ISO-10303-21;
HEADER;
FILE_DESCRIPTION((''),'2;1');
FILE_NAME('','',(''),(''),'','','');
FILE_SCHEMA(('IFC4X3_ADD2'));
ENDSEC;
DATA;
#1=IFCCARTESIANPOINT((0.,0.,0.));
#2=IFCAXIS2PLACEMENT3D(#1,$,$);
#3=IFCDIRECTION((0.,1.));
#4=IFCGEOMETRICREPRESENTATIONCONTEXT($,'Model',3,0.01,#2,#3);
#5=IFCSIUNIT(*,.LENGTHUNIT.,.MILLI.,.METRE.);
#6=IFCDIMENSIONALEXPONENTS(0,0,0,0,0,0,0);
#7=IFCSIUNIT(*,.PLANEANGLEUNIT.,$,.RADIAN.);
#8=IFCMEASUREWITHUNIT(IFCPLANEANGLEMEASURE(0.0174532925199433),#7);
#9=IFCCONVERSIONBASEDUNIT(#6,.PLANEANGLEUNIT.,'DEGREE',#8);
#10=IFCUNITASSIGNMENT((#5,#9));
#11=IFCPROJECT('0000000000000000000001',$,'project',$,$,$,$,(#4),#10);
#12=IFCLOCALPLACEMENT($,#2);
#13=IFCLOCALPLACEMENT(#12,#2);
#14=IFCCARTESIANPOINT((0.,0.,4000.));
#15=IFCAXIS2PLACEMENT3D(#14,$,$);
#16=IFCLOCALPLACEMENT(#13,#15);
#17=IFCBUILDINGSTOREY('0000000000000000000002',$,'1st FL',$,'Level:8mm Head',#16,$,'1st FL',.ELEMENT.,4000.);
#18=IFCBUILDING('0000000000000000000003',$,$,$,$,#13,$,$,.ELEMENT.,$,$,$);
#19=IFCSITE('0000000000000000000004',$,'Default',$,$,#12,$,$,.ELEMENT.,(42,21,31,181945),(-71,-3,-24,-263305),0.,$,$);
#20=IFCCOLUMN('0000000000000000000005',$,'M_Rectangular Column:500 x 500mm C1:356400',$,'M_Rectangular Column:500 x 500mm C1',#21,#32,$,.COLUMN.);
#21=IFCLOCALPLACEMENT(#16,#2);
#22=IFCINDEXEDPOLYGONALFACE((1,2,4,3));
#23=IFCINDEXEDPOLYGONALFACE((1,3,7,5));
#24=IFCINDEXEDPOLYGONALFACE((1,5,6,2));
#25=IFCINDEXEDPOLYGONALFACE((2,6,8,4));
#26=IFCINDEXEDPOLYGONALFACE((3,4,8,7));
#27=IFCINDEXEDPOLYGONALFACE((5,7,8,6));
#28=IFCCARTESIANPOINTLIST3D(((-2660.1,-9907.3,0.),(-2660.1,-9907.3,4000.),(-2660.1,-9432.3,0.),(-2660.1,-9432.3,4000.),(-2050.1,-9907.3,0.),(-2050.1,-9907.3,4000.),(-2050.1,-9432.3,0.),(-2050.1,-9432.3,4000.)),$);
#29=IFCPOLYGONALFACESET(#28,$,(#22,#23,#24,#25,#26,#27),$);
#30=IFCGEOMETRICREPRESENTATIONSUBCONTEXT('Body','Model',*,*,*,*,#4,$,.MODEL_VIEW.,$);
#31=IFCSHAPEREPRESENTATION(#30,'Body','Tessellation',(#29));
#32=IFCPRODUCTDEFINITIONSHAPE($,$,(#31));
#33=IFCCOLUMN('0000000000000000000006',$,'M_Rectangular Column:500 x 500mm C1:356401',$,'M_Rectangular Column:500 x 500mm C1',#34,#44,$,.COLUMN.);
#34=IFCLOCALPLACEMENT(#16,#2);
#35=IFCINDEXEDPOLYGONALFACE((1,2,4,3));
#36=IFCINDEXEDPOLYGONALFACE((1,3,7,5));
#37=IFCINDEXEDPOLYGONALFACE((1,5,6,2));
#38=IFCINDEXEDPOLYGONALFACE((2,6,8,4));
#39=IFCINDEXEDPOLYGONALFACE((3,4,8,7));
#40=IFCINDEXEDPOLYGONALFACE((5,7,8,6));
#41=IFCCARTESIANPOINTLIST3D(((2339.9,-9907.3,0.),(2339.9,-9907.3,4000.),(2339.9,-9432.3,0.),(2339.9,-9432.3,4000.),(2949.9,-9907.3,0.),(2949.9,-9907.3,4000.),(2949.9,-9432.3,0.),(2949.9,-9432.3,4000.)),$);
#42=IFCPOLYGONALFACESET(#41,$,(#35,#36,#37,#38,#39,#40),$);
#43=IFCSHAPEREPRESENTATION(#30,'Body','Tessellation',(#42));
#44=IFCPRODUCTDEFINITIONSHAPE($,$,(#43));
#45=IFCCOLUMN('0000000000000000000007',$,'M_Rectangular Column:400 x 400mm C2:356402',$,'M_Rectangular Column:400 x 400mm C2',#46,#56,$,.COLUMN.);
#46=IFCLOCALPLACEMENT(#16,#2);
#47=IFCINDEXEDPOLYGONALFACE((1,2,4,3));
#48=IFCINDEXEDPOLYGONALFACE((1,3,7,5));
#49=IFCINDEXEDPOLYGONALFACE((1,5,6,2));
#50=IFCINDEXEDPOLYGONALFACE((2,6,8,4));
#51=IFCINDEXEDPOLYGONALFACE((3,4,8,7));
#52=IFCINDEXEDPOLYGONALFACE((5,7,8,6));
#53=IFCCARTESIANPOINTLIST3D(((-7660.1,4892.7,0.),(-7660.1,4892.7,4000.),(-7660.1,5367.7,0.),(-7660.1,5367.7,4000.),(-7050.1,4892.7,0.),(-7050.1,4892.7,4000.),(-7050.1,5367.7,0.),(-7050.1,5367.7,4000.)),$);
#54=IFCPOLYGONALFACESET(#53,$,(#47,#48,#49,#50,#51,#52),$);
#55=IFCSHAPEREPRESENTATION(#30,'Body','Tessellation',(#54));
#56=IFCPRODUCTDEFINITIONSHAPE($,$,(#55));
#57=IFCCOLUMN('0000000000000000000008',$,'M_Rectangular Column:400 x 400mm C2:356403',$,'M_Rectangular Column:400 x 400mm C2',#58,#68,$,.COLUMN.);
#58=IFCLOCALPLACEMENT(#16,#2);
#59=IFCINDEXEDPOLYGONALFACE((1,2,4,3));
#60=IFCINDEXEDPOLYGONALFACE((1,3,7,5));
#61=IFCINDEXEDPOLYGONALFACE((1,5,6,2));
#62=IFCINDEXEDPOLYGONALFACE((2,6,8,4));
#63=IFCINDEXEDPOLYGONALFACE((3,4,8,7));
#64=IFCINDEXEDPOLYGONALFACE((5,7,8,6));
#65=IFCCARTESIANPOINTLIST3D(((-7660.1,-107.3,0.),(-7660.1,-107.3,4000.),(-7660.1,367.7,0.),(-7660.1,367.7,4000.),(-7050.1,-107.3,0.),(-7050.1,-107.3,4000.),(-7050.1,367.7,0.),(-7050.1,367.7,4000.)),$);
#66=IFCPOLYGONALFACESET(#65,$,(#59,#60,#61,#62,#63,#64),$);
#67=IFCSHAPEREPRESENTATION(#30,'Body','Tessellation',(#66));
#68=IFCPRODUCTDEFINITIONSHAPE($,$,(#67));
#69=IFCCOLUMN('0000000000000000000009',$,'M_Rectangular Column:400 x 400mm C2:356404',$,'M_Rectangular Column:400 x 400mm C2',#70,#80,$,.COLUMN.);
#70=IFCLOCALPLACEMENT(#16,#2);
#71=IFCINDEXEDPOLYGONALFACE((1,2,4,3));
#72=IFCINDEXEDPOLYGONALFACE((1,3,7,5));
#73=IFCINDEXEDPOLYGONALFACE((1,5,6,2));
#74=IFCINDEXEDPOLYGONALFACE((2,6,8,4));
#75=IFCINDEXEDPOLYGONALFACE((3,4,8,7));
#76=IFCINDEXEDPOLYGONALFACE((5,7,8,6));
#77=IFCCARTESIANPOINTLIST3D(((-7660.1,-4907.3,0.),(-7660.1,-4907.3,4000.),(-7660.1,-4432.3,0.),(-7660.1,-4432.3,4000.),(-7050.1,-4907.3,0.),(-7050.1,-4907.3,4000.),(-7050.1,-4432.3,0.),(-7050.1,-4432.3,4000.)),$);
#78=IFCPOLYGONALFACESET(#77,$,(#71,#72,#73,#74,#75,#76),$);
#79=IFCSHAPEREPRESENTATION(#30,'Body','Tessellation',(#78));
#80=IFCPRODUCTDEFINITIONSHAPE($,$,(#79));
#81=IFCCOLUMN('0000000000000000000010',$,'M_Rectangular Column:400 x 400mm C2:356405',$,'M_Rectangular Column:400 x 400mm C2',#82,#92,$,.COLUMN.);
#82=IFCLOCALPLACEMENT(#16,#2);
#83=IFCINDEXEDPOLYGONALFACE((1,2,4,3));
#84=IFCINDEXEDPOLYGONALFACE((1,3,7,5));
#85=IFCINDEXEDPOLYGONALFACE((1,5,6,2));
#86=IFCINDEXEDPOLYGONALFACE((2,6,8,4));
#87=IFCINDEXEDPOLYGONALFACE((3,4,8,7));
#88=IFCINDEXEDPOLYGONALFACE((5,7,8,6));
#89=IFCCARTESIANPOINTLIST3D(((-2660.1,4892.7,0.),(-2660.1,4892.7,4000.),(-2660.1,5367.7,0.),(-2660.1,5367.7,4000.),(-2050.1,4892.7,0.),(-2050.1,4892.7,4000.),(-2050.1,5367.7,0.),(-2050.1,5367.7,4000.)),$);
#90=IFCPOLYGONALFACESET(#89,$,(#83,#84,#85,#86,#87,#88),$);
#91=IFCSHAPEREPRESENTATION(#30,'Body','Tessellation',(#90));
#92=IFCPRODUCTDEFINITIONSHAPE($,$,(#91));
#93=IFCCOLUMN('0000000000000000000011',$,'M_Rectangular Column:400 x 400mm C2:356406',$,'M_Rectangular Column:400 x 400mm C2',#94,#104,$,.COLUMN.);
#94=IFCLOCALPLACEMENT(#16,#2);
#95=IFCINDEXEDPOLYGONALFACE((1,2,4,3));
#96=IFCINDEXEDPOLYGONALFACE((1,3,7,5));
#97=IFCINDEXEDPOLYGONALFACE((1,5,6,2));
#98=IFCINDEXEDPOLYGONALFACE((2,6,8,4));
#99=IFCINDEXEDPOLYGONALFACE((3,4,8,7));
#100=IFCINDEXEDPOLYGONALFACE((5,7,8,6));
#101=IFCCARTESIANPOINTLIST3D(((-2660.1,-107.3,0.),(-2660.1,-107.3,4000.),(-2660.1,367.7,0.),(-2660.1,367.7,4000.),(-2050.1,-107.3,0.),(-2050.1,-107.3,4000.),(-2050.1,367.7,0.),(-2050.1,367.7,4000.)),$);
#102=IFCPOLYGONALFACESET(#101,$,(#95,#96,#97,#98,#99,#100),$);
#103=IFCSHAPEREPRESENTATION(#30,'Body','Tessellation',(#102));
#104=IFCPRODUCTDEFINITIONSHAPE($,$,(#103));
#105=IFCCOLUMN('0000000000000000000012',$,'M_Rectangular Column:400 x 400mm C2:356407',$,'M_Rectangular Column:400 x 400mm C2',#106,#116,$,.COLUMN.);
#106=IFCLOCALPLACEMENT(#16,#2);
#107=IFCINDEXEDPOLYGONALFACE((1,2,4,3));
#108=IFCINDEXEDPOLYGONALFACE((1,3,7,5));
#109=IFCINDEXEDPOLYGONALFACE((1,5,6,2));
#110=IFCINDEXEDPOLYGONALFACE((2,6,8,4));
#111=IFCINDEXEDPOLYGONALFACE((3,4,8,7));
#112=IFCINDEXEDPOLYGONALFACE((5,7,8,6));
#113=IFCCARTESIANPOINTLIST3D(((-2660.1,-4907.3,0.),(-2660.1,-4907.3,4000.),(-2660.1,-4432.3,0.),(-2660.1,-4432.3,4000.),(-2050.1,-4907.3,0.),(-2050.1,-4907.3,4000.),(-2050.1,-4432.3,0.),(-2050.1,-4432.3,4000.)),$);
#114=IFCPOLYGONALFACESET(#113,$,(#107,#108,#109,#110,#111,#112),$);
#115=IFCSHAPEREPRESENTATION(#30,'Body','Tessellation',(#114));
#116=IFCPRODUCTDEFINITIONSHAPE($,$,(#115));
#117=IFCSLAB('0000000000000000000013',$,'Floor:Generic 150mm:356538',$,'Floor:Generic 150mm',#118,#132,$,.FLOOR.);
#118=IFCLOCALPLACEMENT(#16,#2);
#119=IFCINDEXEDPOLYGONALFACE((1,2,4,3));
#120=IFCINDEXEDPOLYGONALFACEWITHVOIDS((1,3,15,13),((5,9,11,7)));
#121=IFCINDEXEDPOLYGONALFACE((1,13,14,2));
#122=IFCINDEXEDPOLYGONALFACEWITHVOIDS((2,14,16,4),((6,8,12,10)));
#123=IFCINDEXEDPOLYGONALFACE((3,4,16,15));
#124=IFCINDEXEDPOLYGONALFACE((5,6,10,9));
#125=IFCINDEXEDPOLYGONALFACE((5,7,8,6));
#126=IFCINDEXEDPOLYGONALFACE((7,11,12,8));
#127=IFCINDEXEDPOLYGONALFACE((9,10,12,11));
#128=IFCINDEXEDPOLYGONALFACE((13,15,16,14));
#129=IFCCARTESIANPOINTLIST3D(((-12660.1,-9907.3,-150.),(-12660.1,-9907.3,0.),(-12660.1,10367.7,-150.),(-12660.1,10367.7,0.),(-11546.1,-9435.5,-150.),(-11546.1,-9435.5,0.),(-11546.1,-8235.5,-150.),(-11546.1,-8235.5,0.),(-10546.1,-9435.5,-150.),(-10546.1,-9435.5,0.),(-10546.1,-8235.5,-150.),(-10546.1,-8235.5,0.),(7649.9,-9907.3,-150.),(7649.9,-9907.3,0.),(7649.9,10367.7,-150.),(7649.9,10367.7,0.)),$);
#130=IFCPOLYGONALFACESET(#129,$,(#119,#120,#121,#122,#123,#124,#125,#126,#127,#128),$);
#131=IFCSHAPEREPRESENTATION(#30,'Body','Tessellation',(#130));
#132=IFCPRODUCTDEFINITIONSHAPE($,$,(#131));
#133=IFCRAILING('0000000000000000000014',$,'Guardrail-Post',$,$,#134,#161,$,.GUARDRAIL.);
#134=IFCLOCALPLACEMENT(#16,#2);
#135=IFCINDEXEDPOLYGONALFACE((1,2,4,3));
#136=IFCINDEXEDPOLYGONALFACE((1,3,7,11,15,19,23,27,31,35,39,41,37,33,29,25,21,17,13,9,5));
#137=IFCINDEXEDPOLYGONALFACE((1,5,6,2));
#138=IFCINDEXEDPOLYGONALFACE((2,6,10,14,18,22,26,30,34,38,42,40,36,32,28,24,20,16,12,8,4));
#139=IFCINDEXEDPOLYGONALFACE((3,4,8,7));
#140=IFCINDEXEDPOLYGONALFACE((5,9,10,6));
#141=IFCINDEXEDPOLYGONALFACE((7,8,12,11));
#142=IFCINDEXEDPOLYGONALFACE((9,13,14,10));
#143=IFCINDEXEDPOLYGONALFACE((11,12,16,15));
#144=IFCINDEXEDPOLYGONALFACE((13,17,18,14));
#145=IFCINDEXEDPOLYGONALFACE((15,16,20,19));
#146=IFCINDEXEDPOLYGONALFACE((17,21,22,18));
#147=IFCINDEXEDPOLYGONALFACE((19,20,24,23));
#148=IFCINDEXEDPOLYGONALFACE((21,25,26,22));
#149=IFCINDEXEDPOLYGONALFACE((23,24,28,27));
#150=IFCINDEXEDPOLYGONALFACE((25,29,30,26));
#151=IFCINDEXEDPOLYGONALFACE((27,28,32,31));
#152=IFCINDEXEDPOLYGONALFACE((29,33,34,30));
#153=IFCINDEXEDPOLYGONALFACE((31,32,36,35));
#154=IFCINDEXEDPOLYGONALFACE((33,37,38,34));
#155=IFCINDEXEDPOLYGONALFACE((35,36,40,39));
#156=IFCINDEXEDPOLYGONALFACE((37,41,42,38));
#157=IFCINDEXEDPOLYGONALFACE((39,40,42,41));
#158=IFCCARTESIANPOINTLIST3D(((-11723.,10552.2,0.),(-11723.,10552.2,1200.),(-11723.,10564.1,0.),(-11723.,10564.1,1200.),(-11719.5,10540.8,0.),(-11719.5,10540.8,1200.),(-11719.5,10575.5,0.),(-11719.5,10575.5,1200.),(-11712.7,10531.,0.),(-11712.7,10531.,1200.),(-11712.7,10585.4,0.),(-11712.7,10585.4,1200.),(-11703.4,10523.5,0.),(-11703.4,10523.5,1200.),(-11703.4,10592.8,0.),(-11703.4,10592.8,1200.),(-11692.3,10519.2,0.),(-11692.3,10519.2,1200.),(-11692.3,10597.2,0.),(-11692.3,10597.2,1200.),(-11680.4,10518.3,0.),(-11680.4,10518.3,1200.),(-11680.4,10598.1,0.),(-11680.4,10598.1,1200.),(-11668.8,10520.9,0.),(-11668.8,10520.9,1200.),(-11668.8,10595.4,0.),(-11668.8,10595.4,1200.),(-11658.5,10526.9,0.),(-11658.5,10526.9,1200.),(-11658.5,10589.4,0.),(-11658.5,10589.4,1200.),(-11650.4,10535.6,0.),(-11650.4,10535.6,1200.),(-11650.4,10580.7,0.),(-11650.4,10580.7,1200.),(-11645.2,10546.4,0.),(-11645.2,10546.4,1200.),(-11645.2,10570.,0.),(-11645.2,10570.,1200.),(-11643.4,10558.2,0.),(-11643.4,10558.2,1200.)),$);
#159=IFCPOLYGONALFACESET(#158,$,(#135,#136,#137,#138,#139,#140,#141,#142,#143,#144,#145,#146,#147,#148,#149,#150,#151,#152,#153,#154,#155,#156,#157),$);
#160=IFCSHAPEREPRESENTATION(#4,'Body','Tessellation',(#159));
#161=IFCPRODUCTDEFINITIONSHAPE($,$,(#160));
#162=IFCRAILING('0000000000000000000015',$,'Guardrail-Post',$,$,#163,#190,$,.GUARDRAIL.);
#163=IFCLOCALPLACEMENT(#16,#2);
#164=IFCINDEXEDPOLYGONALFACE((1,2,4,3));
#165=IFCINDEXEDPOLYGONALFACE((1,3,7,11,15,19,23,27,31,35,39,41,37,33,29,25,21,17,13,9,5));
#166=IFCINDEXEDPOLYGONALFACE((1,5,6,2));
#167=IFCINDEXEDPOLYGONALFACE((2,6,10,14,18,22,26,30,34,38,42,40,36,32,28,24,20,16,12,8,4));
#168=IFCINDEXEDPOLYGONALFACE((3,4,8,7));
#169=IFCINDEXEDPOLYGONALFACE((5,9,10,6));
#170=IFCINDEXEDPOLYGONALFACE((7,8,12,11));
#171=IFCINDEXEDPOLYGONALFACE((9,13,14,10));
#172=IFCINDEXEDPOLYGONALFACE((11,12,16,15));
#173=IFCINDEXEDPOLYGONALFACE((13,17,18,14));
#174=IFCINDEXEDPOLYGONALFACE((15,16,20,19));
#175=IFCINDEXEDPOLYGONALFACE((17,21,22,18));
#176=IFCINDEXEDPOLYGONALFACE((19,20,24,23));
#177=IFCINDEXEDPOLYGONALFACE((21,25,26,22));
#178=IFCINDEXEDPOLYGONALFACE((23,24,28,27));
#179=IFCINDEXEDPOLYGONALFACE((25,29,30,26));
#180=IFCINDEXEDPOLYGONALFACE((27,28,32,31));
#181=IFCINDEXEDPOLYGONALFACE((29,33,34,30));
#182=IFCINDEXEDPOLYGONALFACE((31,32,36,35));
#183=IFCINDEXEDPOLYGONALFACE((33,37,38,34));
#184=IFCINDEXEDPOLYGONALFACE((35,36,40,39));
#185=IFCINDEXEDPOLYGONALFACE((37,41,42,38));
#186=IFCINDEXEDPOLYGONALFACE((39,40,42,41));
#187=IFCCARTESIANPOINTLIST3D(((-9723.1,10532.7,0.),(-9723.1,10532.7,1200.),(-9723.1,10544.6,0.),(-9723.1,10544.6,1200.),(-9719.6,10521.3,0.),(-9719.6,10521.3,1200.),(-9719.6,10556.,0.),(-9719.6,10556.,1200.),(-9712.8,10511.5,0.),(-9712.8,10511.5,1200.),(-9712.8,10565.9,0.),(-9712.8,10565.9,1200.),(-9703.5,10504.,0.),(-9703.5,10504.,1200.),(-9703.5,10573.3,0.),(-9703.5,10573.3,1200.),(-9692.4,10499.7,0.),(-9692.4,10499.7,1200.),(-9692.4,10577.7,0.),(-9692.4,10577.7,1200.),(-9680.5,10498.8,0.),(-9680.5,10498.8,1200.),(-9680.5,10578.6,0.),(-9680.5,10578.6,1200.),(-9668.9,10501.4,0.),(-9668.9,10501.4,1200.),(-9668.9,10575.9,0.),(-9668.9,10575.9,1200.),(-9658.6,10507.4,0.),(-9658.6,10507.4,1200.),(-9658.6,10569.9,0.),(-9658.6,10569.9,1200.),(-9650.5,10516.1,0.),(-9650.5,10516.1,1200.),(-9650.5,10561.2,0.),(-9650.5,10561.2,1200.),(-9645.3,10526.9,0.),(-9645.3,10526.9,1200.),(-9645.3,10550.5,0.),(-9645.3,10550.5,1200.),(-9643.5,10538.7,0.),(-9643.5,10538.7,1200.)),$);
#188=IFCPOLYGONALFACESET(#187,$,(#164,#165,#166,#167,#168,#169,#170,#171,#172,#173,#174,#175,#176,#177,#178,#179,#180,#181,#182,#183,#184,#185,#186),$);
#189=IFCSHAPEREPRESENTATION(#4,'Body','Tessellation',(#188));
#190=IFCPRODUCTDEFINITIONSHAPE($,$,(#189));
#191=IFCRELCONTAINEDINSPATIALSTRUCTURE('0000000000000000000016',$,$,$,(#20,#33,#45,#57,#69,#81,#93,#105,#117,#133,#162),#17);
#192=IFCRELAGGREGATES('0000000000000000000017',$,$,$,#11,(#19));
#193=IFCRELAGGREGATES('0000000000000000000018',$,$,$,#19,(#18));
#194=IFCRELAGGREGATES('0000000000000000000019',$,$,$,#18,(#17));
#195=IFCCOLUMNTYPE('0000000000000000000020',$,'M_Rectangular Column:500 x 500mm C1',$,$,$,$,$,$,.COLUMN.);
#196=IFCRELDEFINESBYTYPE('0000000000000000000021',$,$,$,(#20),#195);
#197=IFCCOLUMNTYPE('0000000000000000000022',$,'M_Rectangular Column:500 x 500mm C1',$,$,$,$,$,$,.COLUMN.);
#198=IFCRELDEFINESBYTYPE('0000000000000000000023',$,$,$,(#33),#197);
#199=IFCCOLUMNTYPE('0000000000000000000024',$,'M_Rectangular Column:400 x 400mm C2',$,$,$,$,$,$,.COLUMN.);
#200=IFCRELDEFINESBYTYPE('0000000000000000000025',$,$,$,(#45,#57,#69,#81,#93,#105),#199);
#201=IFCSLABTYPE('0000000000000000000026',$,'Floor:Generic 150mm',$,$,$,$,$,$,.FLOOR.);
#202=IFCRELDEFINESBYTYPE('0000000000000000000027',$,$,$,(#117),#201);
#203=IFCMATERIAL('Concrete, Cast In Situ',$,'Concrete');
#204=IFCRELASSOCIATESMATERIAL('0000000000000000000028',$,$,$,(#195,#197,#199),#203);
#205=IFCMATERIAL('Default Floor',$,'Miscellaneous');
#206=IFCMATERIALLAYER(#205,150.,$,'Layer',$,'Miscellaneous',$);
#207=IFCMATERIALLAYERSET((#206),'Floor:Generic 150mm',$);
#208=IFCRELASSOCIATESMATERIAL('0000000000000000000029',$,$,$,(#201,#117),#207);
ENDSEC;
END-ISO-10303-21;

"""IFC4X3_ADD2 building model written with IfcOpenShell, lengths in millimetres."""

from ifc_helpers import new_model, entity, si_unit, converted_unit, direction, frame, frame_2d, origin, origin_with_axes, origin_2d, origin_2d_with_axis, place, context, subcontext, project, spatial, rectangle, circle, extrude, boolean, source, transform, mapped, material, layer, layer_set, layer_usage, material_profile, profile_set, type_object, type_shapes, element, save


model = new_model("IFC4X3_ADD2")

# Units and contexts
model_context = context("Model", 3, precision=0.01, world=origin(), true_north=direction((0.0, 1.0)))
body_context = subcontext(model_context, "Body", "Model", "MODEL_VIEW")
ifc_project = project(units=[si_unit("LENGTHUNIT", "METRE", prefix="MILLI"), converted_unit("PLANEANGLEUNIT", "DEGREE", entity("IfcPlaneAngleMeasure", 0.0174532925199433), si_unit("PLANEANGLEUNIT", "RADIAN"), dimensions=[0, 0, 0, 0, 0, 0, 0])], contexts=[model_context])

# Site, building, storey
site_placement = place(None, origin())
site = spatial("IfcSite", under=ifc_project, at=site_placement, Name="Default", CompositionType="ELEMENT", RefLatitude=(42, 21, 31, 181945), RefLongitude=(-71, -3, -24, -263305), RefElevation=0.0)
building_placement = place(site_placement, origin())
building = spatial("IfcBuilding", under=site, at=building_placement, CompositionType="ELEMENT")
storey_placement = place(building_placement, frame((0.0, 0.0, 4000.0)))
storey = spatial("IfcBuildingStorey", under=building, at=storey_placement, Name="1st FL", ObjectType="Level:8mm Head", LongName="1st FL", CompositionType="ELEMENT", Elevation=4000.0)

# Columns
ifc_material_1 = material(Name="Concrete, Cast In Situ", Category="Concrete")
ifc_material_profile_1 = material_profile(ifc_material_1, rectangle(XDim=610.0, YDim=475.0, at=frame_2d((0.0, 0.0), x_axis=(1.0, 0.0))), Name="500 x 500mm C1")
ifc_profile_set_1 = profile_set([ifc_material_profile_1], Name="500 x 500mm C1")
column_type_1 = type_object("IfcColumnType", Name="M_Rectangular Column:500 x 500mm C1", PredefinedType="COLUMN", material=ifc_profile_set_1)
shared_shape_1 = source(origin(), body_context, "Body", "SweptSolid", [
    extrude(rectangle(XDim=610.0, YDim=475.0, at=frame_2d((0.0, 0.0), x_axis=(1.0, 0.0))), frame((-2355.1, -9669.8, 4000.0), z_axis=(0.0, 0.0, 1.0), x_axis=(-1.0, 0.0, 0.0)), (0.0, 0.0, 1.0), 4000.0),
])
type_shapes(column_type_1, [shared_shape_1])
column_1_placement = place(storey_placement, frame((0.0, 0.0, -4000.0)))
element("IfcColumn", 1, at=column_1_placement, inside=storey, type_object=column_type_1, Name="M_Rectangular Column:500 x 500mm C1:356400", ObjectType="M_Rectangular Column:500 x 500mm C1", PredefinedType="COLUMN", context=body_context, shape_type="MappedRepresentation", body=[
    mapped(shared_shape_1, transform((0.0, 0.0, 0.0), scale=1.0)),
])
column_type_2 = type_object("IfcColumnType", Name="M_Rectangular Column:500 x 500mm C1", PredefinedType="COLUMN", material=ifc_profile_set_1)
shared_shape_2 = source(origin(), body_context, "Body", "SweptSolid", [
    extrude(rectangle(XDim=610.0, YDim=475.0, at=frame_2d((0.0, 0.0), x_axis=(1.0, 0.0))), frame((2644.9, -9669.8, 4000.0), z_axis=(0.0, 0.0, 1.0), x_axis=(-1.0, 0.0, 0.0)), (0.0, 0.0, 1.0), 4000.0),
])
type_shapes(column_type_2, [shared_shape_2])
column_2_placement = place(storey_placement, frame((0.0, 0.0, -4000.0)))
element("IfcColumn", 2, at=column_2_placement, inside=storey, type_object=column_type_2, Name="M_Rectangular Column:500 x 500mm C1:356401", ObjectType="M_Rectangular Column:500 x 500mm C1", PredefinedType="COLUMN", context=body_context, shape_type="MappedRepresentation", body=[
    mapped(shared_shape_2, transform((0.0, 0.0, 0.0), scale=1.0)),
])
ifc_material_profile_2 = material_profile(ifc_material_1, rectangle(XDim=610.0, YDim=475.0, at=origin_2d_with_axis()), Name="400 x 400mm C2")
ifc_profile_set_2 = profile_set([ifc_material_profile_2], Name="400 x 400mm C2")
column_type_3 = type_object("IfcColumnType", Name="M_Rectangular Column:400 x 400mm C2", PredefinedType="COLUMN", material=ifc_profile_set_2)
shared_shape_3 = source(origin(), body_context, "Body", "SweptSolid", [
    extrude(rectangle(XDim=610.0, YDim=475.0, at=origin_2d_with_axis()), frame((0.0, 0.0, 4000.0), z_axis=(0.0, 0.0, 1.0), x_axis=(-1.0, 0.0, 0.0)), (0.0, 0.0, 1.0), 4000.0),
])
type_shapes(column_type_3, [shared_shape_3])
for number, where, name in (
    (3, (-7355.1, 5130.2, -4000.0), "M_Rectangular Column:400 x 400mm C2:356402"),
    (4, (-7355.1, 130.2, -4000.0), "M_Rectangular Column:400 x 400mm C2:356403"),
    (5, (-7355.1, -4669.8, -4000.0), "M_Rectangular Column:400 x 400mm C2:356404"),
    (6, (-2355.1, 5130.2, -4000.0), "M_Rectangular Column:400 x 400mm C2:356405"),
    (7, (-2355.1, 130.2, -4000.0), "M_Rectangular Column:400 x 400mm C2:356406"),
    (8, (-2355.1, -4669.8, -4000.0), "M_Rectangular Column:400 x 400mm C2:356407"),
):
    element("IfcColumn", number, at=place(storey_placement, frame(where)), inside=storey, type_object=column_type_3, Name=name, ObjectType="M_Rectangular Column:400 x 400mm C2", PredefinedType="COLUMN", context=body_context, shape_type="MappedRepresentation", body=[
        mapped(shared_shape_3, transform((0.0, 0.0, 0.0), scale=1.0)),
    ])

# Slab, opening
ifc_material_2 = material(Name="Default Floor", Category="Miscellaneous")
ifc_layer = layer(ifc_material_2, 150.0, Name="Layer", Category="Miscellaneous")
ifc_layer_set = layer_set([ifc_layer], Name="Floor:Generic 150mm")
ifc_layer_usage = layer_usage(ifc_layer_set, "AXIS3", "POSITIVE", 0.0)
slab_type = type_object("IfcSlabType", Name="Floor:Generic 150mm", PredefinedType="FLOOR", material=ifc_layer_set)
slab_placement = place(storey_placement, origin())
slab = element("IfcSlab", 9, at=slab_placement, inside=storey, type_object=slab_type, material=ifc_layer_usage, Name="Floor:Generic 150mm:356538", ObjectType="Floor:Generic 150mm", PredefinedType="FLOOR", context=body_context, shape_type="SweptSolid", body=[
    boolean("DIFFERENCE", extrude(rectangle(XDim=20275.0, YDim=20310.0, at=origin_2d_with_axis()), frame((-2505.1, 230.2, 0.0), z_axis=(0.0, 0.0, -1.0), x_axis=(0.0, 1.0, 0.0)), (0.0, 0.0, 1.0), 150.0), extrude(rectangle(XDim=1200.0, YDim=1000.0, at=frame_2d((0.0, 0.0), x_axis=(1.0, 0.0))), frame((-11046.1, -8835.5, 0.0), z_axis=(0.0, 0.0, -1.0), x_axis=(0.0, -1.0, 0.0)), (0.0, 0.0, 1.0), 150.0)),
])
opening_placement = place(slab_placement, origin())
element("IfcOpeningElement", 10, at=opening_placement, cuts=slab, PredefinedType="OPENING", context=body_context, shape_type="SweptSolid", body=[
    extrude(rectangle(XDim=1200.0, YDim=1000.0, at=frame_2d((0.0, 0.0), x_axis=(1.0, 0.0))), frame((-11046.1, -8835.5, -150.0), z_axis=(0.0, 0.0, 1.0), x_axis=(0.0, 1.0, 0.0)), (0.0, 0.0, 1.0), 150.0),
])

# Railings
for number, where, z_axis, x_axis, name in (
    (11, (-11683.4, 10558.2, 4000.0), (0.0, 0.0, 1.0), (1.0, 0.0, 0.0), "Guardrail-Post"),
    (12, (-9683.5, 10538.7, 4000.0), (0.0, 0.0, 1.0), (1.0, 0.0, 0.0), "Guardrail-Post"),
):
    element("IfcRailing", number, at=place(None, frame(where, z_axis=z_axis, x_axis=x_axis)), inside=storey, Name=name, PredefinedType="GUARDRAIL", context=model_context, shape_type="SweptSolid", body=[
        extrude(circle(Radius=40.0, at=origin_2d()), origin_with_axes(), (0.0, 0.0, 1.0), 1200.0),
    ])

save(model, "model.ifc")
